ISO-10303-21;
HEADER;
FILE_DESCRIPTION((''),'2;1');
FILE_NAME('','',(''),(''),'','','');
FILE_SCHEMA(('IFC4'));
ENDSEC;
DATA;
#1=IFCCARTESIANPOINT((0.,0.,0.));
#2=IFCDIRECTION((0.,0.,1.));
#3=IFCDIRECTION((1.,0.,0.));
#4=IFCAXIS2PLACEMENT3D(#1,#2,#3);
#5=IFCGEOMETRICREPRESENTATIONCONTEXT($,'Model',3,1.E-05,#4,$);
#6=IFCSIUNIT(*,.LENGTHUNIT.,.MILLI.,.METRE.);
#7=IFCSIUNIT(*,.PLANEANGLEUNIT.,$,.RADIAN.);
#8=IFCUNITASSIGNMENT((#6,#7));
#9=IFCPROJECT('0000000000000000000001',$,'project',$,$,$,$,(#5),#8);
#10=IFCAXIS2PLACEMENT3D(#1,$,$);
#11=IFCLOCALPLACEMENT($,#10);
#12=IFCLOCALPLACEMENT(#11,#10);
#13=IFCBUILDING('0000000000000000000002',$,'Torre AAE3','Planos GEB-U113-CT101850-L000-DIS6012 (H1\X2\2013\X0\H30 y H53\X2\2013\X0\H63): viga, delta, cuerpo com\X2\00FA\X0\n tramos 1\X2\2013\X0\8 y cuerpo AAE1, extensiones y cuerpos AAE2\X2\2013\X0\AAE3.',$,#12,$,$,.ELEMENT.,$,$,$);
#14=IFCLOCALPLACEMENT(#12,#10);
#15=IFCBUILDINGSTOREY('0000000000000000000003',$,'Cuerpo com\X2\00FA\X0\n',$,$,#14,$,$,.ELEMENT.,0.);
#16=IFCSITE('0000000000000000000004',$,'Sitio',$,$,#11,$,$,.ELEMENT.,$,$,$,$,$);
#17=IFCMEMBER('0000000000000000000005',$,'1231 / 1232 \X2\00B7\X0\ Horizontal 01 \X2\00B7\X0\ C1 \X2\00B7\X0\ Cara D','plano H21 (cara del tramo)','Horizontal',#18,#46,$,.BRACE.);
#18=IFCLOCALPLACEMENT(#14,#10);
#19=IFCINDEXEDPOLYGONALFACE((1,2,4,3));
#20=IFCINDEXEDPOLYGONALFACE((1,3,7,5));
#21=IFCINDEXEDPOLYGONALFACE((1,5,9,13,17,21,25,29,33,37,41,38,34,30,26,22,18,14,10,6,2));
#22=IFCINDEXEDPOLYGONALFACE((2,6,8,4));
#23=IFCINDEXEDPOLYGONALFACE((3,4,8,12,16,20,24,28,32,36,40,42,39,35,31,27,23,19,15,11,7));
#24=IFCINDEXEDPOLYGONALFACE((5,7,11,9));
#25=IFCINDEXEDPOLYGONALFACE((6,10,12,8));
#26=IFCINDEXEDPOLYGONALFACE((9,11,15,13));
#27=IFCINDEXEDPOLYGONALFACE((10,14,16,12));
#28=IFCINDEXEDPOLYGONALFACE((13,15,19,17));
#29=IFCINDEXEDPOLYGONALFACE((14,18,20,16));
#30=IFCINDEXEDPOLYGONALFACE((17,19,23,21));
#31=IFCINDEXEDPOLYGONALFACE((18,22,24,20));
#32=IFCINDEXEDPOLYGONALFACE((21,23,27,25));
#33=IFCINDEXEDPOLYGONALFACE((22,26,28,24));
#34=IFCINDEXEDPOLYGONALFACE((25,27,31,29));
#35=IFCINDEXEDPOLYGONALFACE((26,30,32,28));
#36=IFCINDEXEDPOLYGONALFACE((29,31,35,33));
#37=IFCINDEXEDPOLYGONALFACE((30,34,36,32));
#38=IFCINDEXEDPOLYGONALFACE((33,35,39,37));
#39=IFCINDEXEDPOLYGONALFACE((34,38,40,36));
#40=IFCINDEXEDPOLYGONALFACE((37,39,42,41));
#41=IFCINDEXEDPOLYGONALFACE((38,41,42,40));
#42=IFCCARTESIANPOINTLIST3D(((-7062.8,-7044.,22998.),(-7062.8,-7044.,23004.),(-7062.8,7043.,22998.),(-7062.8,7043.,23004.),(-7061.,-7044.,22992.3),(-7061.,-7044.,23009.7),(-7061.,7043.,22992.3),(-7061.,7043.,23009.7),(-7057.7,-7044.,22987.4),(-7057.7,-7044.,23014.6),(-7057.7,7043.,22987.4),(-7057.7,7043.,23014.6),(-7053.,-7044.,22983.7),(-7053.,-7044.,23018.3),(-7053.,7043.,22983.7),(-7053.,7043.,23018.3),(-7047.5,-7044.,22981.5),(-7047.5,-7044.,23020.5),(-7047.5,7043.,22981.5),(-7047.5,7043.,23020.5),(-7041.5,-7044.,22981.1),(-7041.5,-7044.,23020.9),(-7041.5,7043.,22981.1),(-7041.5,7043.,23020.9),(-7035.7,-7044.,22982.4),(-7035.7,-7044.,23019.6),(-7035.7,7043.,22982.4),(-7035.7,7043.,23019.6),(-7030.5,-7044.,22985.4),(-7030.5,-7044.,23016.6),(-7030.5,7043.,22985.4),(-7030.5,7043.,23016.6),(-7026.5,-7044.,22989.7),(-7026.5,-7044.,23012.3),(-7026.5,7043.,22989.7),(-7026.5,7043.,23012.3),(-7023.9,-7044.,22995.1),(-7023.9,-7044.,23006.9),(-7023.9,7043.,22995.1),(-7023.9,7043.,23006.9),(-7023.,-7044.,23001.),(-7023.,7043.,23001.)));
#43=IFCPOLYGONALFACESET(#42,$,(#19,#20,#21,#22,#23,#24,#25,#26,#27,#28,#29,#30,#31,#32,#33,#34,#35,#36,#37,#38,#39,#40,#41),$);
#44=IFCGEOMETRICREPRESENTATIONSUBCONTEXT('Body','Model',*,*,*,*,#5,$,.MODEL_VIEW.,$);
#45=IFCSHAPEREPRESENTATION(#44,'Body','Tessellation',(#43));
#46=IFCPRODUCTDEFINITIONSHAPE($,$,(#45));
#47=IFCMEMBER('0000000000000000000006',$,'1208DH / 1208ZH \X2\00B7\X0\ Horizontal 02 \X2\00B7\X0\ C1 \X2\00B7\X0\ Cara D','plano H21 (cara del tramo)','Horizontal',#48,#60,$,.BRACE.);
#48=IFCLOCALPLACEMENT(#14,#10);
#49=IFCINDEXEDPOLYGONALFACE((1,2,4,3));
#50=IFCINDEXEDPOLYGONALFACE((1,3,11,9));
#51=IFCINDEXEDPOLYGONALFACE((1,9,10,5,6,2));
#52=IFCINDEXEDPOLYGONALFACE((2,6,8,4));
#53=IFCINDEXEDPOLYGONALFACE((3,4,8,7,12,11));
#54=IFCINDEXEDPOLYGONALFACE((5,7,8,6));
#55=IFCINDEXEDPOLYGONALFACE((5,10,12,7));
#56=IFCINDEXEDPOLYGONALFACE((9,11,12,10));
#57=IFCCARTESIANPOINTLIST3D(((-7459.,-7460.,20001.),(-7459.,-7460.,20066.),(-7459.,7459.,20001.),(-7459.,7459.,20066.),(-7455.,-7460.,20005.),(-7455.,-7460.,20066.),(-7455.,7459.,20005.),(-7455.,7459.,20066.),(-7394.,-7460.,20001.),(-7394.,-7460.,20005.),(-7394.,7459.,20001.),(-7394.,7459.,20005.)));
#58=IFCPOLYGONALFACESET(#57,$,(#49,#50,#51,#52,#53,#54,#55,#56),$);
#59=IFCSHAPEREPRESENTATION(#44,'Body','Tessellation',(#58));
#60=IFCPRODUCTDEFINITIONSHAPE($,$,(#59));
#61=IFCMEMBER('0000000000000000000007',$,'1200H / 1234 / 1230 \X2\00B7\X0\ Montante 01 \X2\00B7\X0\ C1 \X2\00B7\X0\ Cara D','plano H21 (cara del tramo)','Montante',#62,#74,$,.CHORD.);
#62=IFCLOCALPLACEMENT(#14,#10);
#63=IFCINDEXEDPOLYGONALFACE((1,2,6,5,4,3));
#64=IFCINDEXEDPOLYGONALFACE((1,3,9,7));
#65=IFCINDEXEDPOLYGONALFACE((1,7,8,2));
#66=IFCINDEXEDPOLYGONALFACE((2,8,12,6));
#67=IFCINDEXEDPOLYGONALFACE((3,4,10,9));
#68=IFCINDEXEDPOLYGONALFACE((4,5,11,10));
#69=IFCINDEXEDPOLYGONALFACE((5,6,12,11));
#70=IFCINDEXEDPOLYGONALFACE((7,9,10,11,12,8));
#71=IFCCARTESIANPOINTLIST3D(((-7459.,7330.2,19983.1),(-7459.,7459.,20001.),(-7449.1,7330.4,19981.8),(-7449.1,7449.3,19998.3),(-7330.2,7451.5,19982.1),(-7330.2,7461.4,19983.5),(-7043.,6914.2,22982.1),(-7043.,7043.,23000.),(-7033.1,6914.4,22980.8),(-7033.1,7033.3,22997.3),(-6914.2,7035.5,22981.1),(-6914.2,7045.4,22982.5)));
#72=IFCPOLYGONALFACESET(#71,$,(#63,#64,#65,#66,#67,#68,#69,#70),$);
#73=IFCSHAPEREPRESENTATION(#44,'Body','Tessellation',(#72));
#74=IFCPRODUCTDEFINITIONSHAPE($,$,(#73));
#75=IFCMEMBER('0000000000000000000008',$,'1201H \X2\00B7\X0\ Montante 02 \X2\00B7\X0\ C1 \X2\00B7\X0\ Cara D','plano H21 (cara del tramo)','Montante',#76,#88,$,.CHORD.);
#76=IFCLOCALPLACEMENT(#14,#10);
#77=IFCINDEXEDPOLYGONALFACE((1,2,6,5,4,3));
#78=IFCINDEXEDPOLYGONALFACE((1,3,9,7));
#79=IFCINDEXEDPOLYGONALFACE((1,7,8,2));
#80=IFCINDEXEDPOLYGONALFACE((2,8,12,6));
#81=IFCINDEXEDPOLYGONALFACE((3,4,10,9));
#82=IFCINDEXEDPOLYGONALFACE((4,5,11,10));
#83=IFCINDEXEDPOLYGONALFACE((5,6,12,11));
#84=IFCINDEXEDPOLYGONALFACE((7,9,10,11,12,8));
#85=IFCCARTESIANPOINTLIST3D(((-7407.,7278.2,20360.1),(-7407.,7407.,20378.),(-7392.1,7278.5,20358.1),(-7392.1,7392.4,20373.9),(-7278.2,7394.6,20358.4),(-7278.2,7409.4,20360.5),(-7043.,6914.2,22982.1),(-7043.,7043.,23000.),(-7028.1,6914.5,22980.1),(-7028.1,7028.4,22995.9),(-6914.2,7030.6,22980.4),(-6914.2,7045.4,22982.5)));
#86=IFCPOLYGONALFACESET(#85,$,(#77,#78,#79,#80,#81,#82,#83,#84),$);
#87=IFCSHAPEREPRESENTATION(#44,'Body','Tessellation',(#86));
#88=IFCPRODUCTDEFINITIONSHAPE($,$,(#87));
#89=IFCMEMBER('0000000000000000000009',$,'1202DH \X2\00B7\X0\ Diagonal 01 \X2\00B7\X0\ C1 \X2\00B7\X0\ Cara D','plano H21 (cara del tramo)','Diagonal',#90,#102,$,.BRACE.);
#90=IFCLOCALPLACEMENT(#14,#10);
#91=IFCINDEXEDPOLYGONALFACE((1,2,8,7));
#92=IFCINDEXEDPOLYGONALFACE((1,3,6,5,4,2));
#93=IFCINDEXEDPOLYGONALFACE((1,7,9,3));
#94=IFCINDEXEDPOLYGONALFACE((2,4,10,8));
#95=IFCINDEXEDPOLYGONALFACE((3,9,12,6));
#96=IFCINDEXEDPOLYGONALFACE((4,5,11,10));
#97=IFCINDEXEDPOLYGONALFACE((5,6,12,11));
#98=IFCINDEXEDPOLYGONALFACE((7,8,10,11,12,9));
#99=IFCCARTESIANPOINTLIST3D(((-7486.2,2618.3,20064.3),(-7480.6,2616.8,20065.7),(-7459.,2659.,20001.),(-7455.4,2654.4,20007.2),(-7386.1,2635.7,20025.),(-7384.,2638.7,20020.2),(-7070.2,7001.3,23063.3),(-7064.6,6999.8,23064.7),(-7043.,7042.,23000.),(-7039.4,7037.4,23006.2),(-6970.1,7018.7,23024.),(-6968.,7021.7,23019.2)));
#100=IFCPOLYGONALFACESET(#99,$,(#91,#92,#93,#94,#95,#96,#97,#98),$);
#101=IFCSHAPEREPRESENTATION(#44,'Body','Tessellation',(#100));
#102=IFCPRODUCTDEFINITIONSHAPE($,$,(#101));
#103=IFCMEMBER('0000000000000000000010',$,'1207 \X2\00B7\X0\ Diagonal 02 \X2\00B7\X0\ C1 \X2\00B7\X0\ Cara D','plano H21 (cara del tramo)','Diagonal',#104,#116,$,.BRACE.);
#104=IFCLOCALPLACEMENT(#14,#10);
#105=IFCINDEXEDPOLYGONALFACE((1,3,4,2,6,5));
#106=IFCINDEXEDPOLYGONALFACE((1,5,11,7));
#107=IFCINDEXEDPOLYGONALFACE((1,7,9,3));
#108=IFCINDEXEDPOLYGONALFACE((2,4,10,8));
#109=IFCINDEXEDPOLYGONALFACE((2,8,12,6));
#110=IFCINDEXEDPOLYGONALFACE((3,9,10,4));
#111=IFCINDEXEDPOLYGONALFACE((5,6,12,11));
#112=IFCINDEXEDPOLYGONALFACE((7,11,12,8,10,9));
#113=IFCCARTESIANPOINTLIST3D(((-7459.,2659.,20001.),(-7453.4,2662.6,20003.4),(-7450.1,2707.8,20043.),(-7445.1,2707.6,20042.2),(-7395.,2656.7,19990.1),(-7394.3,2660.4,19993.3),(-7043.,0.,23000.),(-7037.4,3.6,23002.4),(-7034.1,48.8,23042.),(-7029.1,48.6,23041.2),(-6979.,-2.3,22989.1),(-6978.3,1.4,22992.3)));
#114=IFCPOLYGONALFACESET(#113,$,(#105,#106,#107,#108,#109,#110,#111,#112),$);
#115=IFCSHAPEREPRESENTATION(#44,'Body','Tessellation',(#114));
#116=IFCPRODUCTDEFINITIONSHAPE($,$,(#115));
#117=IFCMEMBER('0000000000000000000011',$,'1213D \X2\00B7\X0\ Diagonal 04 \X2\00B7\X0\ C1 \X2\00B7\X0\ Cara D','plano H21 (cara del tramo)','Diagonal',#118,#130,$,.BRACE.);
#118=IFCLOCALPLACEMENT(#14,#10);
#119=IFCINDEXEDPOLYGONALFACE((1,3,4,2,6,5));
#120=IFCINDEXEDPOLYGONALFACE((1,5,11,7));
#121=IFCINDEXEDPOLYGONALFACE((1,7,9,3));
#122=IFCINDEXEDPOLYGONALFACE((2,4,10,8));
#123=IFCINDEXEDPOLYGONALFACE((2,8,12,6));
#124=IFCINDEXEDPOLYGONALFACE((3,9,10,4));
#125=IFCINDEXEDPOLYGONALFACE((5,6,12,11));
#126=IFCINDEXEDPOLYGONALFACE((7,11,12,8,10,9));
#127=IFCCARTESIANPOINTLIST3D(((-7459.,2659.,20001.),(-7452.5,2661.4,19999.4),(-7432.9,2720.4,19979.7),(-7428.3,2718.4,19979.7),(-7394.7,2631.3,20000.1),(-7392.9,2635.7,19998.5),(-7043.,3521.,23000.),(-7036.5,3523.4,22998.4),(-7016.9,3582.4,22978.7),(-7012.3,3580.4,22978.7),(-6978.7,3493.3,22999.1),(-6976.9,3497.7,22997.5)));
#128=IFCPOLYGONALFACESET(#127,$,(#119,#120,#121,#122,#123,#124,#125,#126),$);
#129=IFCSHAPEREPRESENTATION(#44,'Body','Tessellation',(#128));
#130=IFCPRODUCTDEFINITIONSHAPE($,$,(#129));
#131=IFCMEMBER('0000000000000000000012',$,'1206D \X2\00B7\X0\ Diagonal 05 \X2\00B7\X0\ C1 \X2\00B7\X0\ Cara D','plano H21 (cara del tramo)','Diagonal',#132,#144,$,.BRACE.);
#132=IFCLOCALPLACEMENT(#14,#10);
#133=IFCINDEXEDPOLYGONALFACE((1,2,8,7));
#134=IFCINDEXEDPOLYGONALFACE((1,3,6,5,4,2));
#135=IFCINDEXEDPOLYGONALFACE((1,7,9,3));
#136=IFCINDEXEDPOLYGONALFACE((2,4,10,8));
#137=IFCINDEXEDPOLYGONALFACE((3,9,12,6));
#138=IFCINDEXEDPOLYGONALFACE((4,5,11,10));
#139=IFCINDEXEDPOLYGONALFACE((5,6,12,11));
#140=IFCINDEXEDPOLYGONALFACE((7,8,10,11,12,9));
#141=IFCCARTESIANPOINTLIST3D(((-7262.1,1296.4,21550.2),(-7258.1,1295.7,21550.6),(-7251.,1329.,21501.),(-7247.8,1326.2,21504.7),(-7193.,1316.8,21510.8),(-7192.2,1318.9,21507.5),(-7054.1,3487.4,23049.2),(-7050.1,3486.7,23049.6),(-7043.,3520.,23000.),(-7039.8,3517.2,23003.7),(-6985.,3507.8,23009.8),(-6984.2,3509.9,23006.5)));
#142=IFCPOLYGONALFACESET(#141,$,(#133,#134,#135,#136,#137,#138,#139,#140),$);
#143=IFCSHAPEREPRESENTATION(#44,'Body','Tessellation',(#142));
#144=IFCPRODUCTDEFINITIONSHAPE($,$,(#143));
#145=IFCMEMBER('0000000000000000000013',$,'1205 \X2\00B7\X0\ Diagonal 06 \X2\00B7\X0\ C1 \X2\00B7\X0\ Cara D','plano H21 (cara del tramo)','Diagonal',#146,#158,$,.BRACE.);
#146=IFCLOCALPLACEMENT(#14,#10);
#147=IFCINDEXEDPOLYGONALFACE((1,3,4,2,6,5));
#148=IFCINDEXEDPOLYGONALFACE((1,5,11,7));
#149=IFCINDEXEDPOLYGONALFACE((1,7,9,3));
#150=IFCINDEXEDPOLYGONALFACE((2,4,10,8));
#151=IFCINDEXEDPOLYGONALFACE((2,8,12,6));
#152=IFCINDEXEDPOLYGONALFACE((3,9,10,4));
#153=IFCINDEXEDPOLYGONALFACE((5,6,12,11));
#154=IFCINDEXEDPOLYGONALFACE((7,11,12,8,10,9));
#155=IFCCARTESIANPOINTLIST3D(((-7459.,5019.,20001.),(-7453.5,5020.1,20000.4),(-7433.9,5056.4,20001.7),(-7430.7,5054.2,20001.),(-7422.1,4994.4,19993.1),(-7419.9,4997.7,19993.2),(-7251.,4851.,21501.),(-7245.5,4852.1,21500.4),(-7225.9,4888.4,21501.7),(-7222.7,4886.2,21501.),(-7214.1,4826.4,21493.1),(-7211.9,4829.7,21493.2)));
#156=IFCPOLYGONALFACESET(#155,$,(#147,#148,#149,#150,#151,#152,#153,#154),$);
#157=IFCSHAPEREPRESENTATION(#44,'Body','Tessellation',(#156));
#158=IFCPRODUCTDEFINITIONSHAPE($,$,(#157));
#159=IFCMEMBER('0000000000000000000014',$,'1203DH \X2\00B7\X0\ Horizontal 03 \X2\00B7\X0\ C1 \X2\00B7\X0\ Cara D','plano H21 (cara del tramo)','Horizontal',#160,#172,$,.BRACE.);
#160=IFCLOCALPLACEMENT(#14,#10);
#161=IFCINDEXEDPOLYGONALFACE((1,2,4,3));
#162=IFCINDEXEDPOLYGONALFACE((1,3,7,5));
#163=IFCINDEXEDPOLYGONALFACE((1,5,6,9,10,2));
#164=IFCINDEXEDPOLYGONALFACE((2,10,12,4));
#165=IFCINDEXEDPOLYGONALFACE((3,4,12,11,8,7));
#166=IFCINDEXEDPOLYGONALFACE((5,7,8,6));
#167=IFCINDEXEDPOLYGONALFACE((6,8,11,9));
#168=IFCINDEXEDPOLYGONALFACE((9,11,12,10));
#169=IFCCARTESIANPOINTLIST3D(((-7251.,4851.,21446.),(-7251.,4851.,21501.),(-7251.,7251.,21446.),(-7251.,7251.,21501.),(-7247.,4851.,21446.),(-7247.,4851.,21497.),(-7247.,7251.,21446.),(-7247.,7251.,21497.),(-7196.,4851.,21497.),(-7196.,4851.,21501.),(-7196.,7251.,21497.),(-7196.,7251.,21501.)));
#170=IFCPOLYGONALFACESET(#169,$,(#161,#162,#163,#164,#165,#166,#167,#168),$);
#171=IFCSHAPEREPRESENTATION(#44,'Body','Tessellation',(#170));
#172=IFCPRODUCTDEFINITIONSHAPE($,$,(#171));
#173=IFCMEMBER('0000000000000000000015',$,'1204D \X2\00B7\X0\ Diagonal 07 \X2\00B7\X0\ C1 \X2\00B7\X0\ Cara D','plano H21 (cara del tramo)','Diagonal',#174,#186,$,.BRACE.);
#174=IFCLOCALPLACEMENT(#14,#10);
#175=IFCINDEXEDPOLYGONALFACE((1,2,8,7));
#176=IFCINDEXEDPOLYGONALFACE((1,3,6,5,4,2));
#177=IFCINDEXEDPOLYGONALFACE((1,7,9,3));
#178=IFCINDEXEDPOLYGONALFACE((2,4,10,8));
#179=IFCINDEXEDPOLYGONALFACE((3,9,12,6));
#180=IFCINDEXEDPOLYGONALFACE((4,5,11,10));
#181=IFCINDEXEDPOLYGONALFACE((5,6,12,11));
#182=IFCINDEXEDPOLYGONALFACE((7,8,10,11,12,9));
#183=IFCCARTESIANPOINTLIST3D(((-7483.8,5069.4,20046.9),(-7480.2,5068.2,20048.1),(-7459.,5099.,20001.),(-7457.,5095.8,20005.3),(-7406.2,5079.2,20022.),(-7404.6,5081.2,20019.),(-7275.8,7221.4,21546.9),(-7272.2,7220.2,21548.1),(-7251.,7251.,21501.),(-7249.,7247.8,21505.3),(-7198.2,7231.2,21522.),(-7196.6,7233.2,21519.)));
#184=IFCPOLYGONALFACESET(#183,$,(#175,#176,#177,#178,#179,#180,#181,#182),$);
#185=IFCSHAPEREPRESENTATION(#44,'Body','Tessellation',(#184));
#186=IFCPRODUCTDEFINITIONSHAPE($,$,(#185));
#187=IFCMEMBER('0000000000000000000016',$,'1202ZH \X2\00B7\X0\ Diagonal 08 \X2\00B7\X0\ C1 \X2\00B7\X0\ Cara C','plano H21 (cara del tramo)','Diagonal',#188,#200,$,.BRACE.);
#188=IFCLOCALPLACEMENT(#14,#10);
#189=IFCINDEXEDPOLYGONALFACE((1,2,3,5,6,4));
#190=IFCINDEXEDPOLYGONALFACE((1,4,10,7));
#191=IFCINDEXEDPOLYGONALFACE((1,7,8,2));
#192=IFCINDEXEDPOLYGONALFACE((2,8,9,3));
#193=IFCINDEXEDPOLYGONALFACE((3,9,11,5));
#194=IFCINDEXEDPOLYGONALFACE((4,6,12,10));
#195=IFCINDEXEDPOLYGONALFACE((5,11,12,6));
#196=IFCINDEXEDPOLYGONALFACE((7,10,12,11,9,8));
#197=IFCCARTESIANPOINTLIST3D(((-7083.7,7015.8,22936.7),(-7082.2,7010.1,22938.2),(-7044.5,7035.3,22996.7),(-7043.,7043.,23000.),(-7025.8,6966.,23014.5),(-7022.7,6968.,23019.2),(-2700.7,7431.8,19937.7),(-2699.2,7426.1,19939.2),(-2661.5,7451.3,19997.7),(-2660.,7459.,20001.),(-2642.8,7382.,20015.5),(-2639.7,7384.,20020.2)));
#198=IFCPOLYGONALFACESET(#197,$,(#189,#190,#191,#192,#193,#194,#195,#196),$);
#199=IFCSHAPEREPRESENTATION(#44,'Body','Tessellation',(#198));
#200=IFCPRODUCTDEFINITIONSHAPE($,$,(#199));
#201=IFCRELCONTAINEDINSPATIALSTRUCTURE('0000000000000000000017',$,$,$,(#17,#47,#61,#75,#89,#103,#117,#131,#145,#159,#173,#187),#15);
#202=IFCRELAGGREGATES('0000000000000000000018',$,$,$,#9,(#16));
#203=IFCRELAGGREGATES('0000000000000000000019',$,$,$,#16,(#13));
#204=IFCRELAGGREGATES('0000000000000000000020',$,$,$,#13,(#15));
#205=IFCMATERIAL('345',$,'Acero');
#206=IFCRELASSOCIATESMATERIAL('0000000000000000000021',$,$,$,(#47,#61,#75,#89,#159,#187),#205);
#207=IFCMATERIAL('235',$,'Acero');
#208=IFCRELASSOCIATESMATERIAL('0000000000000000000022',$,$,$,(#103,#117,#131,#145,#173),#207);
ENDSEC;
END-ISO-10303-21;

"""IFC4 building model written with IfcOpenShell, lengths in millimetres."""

from ifc_helpers import new_model, si_unit, frame, frame_2d, origin, origin_with_axes, place, context, subcontext, project, spatial, circle, l_section, extrude, material, element, save


model = new_model("IFC4")

# Units and contexts
model_context = context("Model", 3, precision=1e-05, world=origin_with_axes())
body_context = subcontext(model_context, "Body", "Model", "MODEL_VIEW")
ifc_project = project(units=[si_unit("LENGTHUNIT", "METRE", prefix="MILLI"), si_unit("PLANEANGLEUNIT", "RADIAN")], contexts=[model_context])

# Site, building, storey
site_placement = place(None, origin())
site = spatial("IfcSite", under=ifc_project, at=site_placement, Name="Sitio", CompositionType="ELEMENT")
building_placement = place(site_placement, origin())
building = spatial("IfcBuilding", under=site, at=building_placement, Name="Torre AAE3", Description="Planos GEB-U113-CT101850-L000-DIS6012 (H1–H30 y H53–H63): viga, delta, cuerpo común tramos 1–8 y cuerpo AAE1, extensiones y cuerpos AAE2–AAE3.", CompositionType="ELEMENT")
storey_placement = place(building_placement, origin())
storey = spatial("IfcBuildingStorey", under=building, at=storey_placement, Name="Cuerpo común", CompositionType="ELEMENT", Elevation=0.0)

# Members
ifc_material_1 = material(Name="345", Category="Acero")
ifc_material_2 = material(Name="235", Category="Acero")
member_1_placement = place(storey_placement, frame((-7043.0, 7043.0, 23001.0), z_axis=(0.0, -1.0, 0.0), x_axis=(1.0, 0.0, 0.0)))
element("IfcMember", 1, at=member_1_placement, inside=storey, Name="1231 / 1232 · Horizontal 01 · C1 · Cara D", Description="plano H21 (cara del tramo)", ObjectType="Horizontal", PredefinedType="BRACE", context=body_context, shape_type="SweptSolid", body=[
    extrude(circle(Radius=20.0), None, (0.0, 0.0, 1.0), 14087.0),
])
member_2_placement = place(storey_placement, frame((-7459.0, 7459.0, 20001.0), z_axis=(0.0, -1.0, 0.0), x_axis=(1.0, 0.0, 0.0)))
element("IfcMember", 2, at=member_2_placement, inside=storey, material=ifc_material_1, Name="1208DH / 1208ZH · Horizontal 02 · C1 · Cara D", Description="plano H21 (cara del tramo)", ObjectType="Horizontal", PredefinedType="BRACE", context=body_context, shape_type="SweptSolid", body=[
    extrude(l_section(Depth=65.0, Width=65.0, Thickness=4.0, at=frame_2d((32.5, 32.5))), None, (0.0, 0.0, 1.0), 14919.0),
])
member_3_placement = place(storey_placement, frame((-7043.0, 7043.0, 23000.0), z_axis=(-0.136119, 0.136119, -0.981297), x_axis=(0.990693, 0.018702, -0.134828)))
element("IfcMember", 3, at=member_3_placement, inside=storey, material=ifc_material_1, Name="1200H / 1234 / 1230 · Montante 01 · C1 · Cara D", Description="plano H21 (cara del tramo)", ObjectType="Montante", PredefinedType="CHORD", context=body_context, shape_type="SweptSolid", body=[
    extrude(l_section(Depth=130.0, Width=130.0, Thickness=10.0, at=frame_2d((65.0, 65.0))), None, (0.0, 0.0, 1.0), 3056.2),
])
member_4_placement = place(storey_placement, frame((-7043.0, 7043.0, 23000.0), z_axis=(-0.136225, 0.136225, -0.981267), x_axis=(0.990678, 0.018732, -0.134931)))
element("IfcMember", 4, at=member_4_placement, inside=storey, material=ifc_material_1, Name="1201H · Montante 02 · C1 · Cara D", Description="plano H21 (cara del tramo)", ObjectType="Montante", PredefinedType="CHORD", context=body_context, shape_type="SweptSolid", body=[
    extrude(l_section(Depth=130.0, Width=130.0, Thickness=15.0, at=frame_2d((65.0, 65.0))), None, (0.0, 0.0, 1.0), 2672.1),
])
member_5_placement = place(storey_placement, frame((-7043.0, 7042.0, 23000.0), z_axis=(-0.078092, -0.822778, -0.562973), x_axis=(0.937055, -0.253354, 0.240292)))
element("IfcMember", 5, at=member_5_placement, inside=storey, material=ifc_material_1, Name="1202DH · Diagonal 01 · C1 · Cara D", Description="plano H21 (cara del tramo)", ObjectType="Diagonal", PredefinedType="BRACE", context=body_context, shape_type="SweptSolid", body=[
    extrude(l_section(Depth=80.0, Width=80.0, Thickness=6.0, at=frame_2d((40.0, 40.0))), None, (0.0, 0.0, 1.0), 5327.1),
])
member_6_placement = place(storey_placement, frame((-7459.0, 2659.0, 20001.0), z_axis=(0.103237, -0.659874, 0.74425), x_axis=(0.985091, -0.035691, -0.168289)))
element("IfcMember", 6, at=member_6_placement, inside=storey, material=ifc_material_2, Name="1207 · Diagonal 02 · C1 · Cara D", Description="plano H21 (cara del tramo)", ObjectType="Diagonal", PredefinedType="BRACE", context=body_context, shape_type="SweptSolid", body=[
    extrude(l_section(Depth=65.0, Width=65.0, Thickness=5.0, at=frame_2d((32.5, 32.5))), None, (0.0, 0.0, 1.0), 4029.6),
])
member_7_placement = place(storey_placement, frame((-7459.0, 2659.0, 20001.0), z_axis=(0.132146, 0.273822, 0.952659), x_axis=(0.918164, -0.395969, -0.013548)))
element("IfcMember", 7, at=member_7_placement, inside=storey, material=ifc_material_2, Name="1213D · Diagonal 04 · C1 · Cara D", Description="plano H21 (cara del tramo)", ObjectType="Diagonal", PredefinedType="BRACE", context=body_context, shape_type="SweptSolid", body=[
    extrude(l_section(Depth=70.0, Width=70.0, Thickness=5.0, at=frame_2d((35.0, 35.0))), None, (0.0, 0.0, 1.0), 3148.0),
])
member_8_placement = place(storey_placement, frame((-7043.0, 3520.0, 23000.0), z_axis=(-0.078112, -0.822804, -0.562932), x_axis=(0.979778, -0.167693, 0.109153)))
element("IfcMember", 8, at=member_8_placement, inside=storey, material=ifc_material_2, Name="1206D · Diagonal 05 · C1 · Cara D", Description="plano H21 (cara del tramo)", ObjectType="Diagonal", PredefinedType="BRACE", context=body_context, shape_type="SweptSolid", body=[
    extrude(l_section(Depth=60.0, Width=60.0, Thickness=4.0, at=frame_2d((30.0, 30.0))), None, (0.0, 0.0, 1.0), 2662.8),
])
member_9_placement = place(storey_placement, frame((-7459.0, 5019.0, 20001.0), z_axis=(0.136515, -0.110262, 0.984483), x_axis=(0.819145, -0.54631, -0.174775)))
element("IfcMember", 9, at=member_9_placement, inside=storey, material=ifc_material_2, Name="1205 · Diagonal 06 · C1 · Cara D", Description="plano H21 (cara del tramo)", ObjectType="Diagonal", PredefinedType="BRACE", context=body_context, shape_type="SweptSolid", body=[
    extrude(l_section(Depth=45.0, Width=45.0, Thickness=4.0, at=frame_2d((22.5, 22.5))), None, (0.0, 0.0, 1.0), 1523.6),
])
member_10_placement = place(storey_placement, frame((-7251.0, 4851.0, 21501.0), z_axis=(0.0, 1.0, 0.0), x_axis=(1.0, 0.0, 0.0)))
element("IfcMember", 10, at=member_10_placement, inside=storey, material=ifc_material_1, Name="1203DH · Horizontal 03 · C1 · Cara D", Description="plano H21 (cara del tramo)", ObjectType="Horizontal", PredefinedType="BRACE", context=body_context, shape_type="SweptSolid", body=[
    extrude(l_section(Depth=55.0, Width=55.0, Thickness=4.0, at=frame_2d((27.5, 27.5))), None, (0.0, 0.0, 1.0), 2400.0),
])
member_11_placement = place(storey_placement, frame((-7251.0, 7251.0, 21501.0), z_axis=(-0.079045, -0.81781, -0.570035), x_axis=(0.906797, -0.296517, 0.29966)))
element("IfcMember", 11, at=member_11_placement, inside=storey, material=ifc_material_2, Name="1204D · Diagonal 07 · C1 · Cara D", Description="plano H21 (cara del tramo)", ObjectType="Diagonal", PredefinedType="BRACE", context=body_context, shape_type="SweptSolid", body=[
    extrude(l_section(Depth=60.0, Width=60.0, Thickness=4.0, at=frame_2d((30.0, 30.0))), None, (0.0, 0.0, 1.0), 2631.4),
])
member_12_placement = place(storey_placement, frame((-7043.0, 7043.0, 23000.0), z_axis=(0.822778, 0.078092, -0.562973), x_axis=(0.253386, -0.937033, 0.240342)))
element("IfcMember", 12, at=member_12_placement, inside=storey, material=ifc_material_1, Name="1202ZH · Diagonal 08 · C1 · Cara C", Description="plano H21 (cara del tramo)", ObjectType="Diagonal", PredefinedType="BRACE", context=body_context, shape_type="SweptSolid", body=[
    extrude(l_section(Depth=80.0, Width=80.0, Thickness=6.0, at=frame_2d((40.0, 40.0))), None, (0.0, 0.0, 1.0), 5327.1),
])

save(model, "model.ifc")
